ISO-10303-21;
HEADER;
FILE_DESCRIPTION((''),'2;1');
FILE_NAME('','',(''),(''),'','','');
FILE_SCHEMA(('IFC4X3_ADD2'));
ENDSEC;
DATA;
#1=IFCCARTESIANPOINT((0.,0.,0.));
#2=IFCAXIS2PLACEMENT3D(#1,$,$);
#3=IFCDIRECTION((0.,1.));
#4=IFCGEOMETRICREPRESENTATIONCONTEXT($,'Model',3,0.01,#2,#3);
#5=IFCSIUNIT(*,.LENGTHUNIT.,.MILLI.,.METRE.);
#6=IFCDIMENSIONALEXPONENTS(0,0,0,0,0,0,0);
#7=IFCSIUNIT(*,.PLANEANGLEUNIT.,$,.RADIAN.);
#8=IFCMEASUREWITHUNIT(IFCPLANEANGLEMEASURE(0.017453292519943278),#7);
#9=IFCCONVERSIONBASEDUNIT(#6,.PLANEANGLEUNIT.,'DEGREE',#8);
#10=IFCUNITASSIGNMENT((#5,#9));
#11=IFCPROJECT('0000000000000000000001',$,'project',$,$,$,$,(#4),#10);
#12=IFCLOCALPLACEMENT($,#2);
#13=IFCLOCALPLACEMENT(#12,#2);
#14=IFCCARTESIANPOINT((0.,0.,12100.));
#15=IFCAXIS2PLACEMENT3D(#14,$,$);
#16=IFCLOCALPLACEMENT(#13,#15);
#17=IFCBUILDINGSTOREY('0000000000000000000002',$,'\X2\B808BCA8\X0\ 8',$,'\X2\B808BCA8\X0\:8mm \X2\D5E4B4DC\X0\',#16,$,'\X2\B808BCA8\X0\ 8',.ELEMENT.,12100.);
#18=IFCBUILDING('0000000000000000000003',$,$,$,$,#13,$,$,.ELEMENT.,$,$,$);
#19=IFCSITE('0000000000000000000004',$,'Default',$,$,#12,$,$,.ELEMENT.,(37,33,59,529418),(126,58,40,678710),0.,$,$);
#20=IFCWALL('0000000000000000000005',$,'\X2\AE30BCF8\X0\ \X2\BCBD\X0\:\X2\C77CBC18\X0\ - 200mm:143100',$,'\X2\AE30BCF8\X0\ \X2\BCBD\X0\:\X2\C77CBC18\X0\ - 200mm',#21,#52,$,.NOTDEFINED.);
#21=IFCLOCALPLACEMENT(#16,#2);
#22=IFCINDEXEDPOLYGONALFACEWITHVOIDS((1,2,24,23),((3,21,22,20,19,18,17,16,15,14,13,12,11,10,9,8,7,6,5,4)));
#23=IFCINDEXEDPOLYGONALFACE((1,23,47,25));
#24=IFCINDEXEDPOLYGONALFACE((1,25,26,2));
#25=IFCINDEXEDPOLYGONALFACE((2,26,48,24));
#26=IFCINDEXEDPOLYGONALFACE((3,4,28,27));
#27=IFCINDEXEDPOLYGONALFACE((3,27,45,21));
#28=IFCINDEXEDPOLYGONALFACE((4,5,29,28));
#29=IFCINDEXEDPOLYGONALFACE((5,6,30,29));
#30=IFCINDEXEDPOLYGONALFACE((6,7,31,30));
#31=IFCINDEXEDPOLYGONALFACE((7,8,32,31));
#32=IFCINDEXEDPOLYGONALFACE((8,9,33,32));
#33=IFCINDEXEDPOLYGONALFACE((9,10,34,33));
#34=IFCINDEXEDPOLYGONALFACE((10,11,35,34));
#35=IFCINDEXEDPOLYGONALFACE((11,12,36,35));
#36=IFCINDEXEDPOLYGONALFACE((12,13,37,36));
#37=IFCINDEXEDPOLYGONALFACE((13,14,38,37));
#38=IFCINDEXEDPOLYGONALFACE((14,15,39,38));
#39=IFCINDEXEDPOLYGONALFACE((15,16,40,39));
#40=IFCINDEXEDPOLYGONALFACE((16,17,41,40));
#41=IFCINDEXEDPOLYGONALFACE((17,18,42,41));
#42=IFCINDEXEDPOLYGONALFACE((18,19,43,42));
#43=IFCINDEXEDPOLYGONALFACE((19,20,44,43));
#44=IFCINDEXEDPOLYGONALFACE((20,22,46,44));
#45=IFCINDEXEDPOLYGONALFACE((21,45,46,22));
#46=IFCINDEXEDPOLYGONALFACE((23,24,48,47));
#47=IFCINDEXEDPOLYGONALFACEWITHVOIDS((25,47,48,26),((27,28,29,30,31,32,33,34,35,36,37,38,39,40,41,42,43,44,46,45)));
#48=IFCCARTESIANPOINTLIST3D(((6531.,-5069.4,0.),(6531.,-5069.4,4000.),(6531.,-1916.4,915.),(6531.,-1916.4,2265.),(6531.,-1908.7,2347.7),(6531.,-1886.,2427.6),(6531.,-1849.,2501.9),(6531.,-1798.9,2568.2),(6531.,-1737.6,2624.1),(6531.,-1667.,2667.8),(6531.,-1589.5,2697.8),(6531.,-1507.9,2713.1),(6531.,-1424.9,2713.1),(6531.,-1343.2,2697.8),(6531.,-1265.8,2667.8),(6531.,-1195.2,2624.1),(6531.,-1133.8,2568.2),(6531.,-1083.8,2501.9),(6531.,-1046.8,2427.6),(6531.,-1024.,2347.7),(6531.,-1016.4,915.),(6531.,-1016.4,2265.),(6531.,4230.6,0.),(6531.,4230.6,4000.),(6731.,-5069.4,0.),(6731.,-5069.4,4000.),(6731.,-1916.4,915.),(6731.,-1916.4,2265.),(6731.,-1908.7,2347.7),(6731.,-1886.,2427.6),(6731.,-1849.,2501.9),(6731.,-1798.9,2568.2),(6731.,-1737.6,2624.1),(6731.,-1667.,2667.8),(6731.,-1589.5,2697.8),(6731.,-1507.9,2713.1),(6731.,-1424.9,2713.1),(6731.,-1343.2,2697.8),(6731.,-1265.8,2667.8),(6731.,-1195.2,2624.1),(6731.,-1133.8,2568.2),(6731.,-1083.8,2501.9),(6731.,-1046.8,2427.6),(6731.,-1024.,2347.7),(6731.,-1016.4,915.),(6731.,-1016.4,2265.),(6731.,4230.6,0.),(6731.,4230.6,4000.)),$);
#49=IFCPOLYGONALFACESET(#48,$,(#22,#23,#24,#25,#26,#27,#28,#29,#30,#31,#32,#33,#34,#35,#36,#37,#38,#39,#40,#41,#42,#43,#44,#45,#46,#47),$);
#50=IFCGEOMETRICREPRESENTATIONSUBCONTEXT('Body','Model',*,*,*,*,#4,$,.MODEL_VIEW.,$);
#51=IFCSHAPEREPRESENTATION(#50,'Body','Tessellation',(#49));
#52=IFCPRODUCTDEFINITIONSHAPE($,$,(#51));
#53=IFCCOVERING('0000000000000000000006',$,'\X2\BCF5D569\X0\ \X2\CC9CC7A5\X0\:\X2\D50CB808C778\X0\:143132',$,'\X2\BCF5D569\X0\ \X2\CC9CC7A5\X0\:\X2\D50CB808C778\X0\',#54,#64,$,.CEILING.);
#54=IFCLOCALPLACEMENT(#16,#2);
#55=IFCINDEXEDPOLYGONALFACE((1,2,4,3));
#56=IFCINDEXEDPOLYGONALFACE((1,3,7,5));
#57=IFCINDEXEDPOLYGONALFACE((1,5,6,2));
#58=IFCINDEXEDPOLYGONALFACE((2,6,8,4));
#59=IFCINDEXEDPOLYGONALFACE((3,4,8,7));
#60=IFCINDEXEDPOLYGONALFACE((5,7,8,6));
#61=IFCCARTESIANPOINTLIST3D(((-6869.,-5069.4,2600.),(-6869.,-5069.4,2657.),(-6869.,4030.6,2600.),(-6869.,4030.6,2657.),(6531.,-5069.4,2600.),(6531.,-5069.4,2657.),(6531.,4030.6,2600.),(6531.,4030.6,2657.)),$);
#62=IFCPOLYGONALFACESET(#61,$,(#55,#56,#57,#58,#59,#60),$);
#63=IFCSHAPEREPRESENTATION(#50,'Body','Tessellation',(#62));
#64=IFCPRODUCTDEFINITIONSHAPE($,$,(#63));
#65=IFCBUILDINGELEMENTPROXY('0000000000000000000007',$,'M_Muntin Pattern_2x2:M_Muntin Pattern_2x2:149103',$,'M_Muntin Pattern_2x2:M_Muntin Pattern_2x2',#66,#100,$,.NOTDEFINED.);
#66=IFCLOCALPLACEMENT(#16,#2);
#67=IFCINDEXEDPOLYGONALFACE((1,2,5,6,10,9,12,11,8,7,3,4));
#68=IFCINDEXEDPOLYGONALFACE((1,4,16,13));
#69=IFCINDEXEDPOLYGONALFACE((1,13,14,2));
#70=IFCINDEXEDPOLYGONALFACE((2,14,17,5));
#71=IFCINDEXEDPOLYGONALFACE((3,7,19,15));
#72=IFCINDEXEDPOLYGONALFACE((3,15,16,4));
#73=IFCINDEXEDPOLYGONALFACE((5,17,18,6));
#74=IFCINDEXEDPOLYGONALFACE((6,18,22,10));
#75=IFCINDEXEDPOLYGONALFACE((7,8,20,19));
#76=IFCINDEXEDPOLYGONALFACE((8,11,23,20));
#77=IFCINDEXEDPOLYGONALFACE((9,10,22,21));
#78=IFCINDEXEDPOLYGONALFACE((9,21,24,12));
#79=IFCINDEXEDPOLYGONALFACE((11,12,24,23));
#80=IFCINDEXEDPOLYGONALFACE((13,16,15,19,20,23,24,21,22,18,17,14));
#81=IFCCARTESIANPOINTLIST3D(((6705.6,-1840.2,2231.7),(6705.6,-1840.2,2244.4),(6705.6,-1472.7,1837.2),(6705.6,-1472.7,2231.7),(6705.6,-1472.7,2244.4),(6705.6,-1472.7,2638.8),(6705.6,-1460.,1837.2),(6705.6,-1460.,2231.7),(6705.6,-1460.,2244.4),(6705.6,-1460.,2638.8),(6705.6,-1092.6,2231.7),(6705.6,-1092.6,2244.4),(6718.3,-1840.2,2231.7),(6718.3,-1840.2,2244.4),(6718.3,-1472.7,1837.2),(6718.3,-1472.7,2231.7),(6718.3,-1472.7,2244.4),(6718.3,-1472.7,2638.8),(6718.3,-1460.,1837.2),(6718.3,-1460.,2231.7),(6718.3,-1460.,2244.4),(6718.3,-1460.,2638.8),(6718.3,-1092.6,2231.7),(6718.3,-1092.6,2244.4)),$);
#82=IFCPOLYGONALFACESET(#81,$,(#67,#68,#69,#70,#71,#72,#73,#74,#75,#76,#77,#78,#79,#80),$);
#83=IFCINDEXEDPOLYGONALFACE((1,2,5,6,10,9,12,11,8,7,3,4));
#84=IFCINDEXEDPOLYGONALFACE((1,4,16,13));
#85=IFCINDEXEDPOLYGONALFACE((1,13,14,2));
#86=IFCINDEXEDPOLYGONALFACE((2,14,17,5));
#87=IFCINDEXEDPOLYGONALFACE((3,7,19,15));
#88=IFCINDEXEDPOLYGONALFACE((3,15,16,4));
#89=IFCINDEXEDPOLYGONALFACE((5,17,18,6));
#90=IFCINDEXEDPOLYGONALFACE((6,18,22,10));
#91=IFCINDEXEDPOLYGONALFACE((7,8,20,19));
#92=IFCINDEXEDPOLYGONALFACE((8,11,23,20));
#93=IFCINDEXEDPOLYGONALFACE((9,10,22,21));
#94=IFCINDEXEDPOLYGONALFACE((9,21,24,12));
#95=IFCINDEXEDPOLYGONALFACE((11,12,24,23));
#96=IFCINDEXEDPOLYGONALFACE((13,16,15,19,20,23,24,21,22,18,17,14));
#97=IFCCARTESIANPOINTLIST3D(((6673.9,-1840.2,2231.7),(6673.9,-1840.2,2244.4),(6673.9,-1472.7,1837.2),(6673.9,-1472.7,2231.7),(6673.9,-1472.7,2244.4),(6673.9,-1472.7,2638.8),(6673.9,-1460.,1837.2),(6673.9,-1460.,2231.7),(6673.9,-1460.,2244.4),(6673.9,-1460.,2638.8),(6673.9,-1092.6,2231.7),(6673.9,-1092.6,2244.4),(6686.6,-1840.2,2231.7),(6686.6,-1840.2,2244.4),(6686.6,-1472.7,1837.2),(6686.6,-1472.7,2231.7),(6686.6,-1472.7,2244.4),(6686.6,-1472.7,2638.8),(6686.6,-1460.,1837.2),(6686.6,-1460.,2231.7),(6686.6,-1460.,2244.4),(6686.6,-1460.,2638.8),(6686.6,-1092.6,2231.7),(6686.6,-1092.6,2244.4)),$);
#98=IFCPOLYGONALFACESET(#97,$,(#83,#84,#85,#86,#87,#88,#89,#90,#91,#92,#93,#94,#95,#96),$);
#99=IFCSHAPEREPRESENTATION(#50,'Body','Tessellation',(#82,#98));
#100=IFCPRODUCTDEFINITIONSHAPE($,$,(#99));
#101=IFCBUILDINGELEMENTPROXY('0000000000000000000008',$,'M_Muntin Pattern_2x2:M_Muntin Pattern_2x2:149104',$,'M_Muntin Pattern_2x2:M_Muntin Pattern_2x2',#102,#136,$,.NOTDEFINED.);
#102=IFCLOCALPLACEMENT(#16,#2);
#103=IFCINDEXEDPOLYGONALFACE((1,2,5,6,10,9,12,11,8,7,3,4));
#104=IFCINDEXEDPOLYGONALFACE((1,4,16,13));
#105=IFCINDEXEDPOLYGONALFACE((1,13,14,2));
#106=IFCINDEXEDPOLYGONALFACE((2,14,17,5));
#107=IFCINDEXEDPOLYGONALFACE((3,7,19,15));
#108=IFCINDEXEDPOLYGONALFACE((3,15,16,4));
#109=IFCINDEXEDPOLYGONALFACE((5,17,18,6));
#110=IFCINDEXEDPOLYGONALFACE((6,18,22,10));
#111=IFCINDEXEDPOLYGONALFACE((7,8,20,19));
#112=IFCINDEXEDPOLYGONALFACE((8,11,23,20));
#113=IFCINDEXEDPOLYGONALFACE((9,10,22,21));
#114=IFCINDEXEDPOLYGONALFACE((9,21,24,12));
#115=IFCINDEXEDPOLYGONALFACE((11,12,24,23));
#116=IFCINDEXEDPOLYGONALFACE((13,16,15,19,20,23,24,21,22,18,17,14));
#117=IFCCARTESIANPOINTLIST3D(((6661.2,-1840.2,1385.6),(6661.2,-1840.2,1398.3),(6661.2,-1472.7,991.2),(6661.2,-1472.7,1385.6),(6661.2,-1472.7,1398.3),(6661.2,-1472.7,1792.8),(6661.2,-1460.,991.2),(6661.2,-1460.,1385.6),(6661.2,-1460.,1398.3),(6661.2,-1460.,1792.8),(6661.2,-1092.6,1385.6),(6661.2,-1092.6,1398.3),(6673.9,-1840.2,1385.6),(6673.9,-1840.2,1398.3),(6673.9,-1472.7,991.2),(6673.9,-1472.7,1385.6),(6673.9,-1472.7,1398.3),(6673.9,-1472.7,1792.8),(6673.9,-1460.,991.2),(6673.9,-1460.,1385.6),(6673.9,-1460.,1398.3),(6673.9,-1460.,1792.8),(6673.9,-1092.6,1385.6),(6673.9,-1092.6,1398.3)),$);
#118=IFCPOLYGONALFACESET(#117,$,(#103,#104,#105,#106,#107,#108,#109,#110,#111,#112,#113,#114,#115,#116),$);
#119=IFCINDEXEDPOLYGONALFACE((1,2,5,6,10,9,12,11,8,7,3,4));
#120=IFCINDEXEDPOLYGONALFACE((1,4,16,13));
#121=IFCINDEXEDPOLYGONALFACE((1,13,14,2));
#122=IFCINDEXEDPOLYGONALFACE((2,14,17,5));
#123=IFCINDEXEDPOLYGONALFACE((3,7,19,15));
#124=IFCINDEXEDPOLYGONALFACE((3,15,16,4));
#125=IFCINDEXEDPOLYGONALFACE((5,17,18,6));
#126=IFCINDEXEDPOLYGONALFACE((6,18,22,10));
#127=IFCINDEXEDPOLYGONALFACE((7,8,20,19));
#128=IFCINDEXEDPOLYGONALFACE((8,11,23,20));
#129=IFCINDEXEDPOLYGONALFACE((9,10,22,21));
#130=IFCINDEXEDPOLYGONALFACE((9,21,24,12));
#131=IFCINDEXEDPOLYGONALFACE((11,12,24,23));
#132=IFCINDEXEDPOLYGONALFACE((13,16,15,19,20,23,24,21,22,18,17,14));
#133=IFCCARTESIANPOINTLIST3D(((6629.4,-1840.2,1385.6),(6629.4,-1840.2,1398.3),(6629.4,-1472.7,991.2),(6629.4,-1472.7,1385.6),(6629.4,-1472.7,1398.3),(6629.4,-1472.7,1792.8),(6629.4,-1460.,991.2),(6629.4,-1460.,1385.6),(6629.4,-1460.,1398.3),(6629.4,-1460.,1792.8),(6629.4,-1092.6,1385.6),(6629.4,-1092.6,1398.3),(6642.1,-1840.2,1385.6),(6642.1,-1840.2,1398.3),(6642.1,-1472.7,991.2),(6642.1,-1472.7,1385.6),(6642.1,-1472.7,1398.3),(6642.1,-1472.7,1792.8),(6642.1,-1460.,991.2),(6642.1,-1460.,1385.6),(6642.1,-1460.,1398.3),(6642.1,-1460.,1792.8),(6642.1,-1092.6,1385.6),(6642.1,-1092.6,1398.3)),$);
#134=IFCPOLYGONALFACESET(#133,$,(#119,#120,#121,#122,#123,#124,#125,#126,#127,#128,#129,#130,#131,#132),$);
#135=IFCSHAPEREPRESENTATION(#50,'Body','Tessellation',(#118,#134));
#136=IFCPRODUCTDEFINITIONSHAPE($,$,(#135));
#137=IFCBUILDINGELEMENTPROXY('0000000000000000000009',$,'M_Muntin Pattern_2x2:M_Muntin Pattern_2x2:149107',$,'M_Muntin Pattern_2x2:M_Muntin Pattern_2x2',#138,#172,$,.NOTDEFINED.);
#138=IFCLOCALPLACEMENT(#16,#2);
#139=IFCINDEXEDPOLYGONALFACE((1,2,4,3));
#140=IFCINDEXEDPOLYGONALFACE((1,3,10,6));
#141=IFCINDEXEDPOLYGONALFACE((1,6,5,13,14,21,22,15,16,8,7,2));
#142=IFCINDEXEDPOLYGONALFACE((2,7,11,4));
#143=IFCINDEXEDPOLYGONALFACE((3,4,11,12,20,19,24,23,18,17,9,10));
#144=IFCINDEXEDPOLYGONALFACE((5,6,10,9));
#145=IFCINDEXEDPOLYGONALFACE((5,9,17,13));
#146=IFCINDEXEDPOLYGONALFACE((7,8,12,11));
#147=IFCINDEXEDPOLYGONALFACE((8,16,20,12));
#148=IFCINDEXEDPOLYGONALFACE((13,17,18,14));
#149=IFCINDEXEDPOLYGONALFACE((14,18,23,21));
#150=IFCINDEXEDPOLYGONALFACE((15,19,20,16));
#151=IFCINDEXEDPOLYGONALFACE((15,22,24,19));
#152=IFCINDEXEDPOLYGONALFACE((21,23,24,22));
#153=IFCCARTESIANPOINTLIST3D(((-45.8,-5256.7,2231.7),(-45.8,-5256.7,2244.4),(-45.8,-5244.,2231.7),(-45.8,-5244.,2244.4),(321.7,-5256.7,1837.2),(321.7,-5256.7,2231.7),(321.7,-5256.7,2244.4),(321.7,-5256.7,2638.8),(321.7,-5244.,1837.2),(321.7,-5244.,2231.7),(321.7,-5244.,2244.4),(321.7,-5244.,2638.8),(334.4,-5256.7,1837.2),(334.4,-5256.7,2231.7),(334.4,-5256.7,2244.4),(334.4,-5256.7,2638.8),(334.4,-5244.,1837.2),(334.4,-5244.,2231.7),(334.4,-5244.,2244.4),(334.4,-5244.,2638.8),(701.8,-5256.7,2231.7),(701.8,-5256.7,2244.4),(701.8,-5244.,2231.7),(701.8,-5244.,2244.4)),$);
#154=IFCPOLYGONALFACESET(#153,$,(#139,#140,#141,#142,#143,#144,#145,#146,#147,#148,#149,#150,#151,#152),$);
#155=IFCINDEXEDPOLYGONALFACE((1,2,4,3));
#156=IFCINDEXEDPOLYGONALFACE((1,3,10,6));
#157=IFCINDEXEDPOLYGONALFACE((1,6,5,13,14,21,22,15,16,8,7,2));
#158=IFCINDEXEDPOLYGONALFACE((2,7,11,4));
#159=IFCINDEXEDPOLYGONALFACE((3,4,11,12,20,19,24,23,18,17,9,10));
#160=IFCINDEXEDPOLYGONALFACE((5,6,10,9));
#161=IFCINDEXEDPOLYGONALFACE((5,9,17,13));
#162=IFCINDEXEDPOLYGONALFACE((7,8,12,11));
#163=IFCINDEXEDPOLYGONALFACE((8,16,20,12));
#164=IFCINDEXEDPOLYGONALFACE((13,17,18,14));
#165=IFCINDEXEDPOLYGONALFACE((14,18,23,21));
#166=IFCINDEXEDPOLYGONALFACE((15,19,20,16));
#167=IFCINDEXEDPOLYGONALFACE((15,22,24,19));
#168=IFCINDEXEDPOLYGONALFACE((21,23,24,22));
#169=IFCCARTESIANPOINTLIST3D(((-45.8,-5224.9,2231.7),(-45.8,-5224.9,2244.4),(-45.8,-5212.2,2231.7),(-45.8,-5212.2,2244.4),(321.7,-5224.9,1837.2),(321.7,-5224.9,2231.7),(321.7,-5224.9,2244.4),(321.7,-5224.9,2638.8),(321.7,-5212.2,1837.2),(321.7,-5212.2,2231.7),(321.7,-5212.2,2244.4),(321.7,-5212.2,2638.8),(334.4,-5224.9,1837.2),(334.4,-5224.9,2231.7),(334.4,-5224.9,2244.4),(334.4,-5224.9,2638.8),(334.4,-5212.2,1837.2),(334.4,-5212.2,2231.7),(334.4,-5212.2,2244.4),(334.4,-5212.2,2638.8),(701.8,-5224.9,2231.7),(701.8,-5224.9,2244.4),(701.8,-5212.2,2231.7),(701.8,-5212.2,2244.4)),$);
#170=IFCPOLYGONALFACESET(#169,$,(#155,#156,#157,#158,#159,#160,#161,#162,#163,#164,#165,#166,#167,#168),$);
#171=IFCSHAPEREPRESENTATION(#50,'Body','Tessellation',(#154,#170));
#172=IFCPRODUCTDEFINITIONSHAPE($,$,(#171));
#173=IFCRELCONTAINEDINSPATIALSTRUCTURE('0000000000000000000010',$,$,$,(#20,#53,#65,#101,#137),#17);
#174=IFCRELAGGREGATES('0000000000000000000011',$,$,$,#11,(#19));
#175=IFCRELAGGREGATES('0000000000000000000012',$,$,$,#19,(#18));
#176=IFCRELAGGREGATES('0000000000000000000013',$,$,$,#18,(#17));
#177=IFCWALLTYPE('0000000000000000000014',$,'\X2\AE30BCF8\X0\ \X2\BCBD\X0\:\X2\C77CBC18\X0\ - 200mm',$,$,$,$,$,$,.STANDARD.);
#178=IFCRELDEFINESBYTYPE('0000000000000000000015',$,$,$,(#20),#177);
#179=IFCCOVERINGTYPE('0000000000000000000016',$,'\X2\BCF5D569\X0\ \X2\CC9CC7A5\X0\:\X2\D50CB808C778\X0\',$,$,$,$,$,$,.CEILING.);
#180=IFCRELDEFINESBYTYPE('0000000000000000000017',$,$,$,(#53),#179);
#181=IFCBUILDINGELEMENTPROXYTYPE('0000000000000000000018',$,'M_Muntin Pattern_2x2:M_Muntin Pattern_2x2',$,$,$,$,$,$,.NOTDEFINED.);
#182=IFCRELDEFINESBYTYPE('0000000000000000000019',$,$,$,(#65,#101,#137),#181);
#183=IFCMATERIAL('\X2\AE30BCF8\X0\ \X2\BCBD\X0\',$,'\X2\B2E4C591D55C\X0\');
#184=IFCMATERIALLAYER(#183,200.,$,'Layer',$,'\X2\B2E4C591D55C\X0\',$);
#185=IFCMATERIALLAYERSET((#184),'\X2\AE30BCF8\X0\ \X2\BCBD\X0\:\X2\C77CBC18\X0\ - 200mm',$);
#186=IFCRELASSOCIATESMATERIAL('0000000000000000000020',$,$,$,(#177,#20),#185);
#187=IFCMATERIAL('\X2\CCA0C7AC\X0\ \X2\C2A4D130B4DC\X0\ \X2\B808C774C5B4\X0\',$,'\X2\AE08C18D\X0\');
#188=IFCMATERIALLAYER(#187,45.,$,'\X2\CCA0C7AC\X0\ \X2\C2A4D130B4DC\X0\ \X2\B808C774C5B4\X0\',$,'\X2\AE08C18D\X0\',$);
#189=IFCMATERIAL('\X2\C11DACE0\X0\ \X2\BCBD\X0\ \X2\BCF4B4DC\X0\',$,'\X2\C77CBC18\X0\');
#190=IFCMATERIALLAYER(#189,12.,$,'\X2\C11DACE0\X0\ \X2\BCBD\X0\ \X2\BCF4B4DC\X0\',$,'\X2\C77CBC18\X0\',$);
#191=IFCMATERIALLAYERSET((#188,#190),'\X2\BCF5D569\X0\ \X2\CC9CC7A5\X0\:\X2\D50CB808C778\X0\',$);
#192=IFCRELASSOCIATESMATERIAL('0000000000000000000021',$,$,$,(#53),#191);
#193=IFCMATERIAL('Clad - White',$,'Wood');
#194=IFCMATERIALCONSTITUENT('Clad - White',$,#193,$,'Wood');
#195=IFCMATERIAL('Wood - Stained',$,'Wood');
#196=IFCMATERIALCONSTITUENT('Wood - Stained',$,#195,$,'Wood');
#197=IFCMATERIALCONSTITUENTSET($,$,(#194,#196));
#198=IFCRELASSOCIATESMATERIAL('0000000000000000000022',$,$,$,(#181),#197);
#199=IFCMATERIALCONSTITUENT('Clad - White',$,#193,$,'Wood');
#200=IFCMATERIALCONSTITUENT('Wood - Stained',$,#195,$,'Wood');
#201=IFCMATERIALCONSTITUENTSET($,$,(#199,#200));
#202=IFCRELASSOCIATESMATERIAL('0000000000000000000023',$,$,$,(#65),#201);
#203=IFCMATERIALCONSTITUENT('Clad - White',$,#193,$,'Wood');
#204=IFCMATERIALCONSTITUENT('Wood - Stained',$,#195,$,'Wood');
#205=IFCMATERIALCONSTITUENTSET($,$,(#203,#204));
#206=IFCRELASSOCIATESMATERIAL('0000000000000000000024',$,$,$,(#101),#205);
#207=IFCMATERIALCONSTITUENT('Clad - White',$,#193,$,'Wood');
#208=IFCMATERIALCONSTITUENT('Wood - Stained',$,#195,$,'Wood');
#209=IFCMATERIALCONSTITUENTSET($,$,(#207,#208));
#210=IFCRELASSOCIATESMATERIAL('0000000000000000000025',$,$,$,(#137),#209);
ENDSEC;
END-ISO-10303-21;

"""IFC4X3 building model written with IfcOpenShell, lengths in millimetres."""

from ifc_helpers import new_model, entity, si_unit, converted_unit, direction, frame, frame_2d, origin, origin_2d_with_axis, place, context, subcontext, project, spatial, polyline, circle_curve, parameter, trimmed, segment, composite_curve, rectangle, outline, extrude, source, transform, mapped, material, layer, layer_set, layer_usage, constituent, constituent_set, type_object, type_shapes, element, save


model = new_model("IFC4X3")

# Units and contexts
model_context = context("Model", 3, precision=0.01, world=origin(), true_north=direction((0.0, 1.0)))
body_context = subcontext(model_context, "Body", "Model", "MODEL_VIEW")
ifc_project = project(units=[si_unit("LENGTHUNIT", "METRE", prefix="MILLI"), converted_unit("PLANEANGLEUNIT", "DEGREE", entity("IfcPlaneAngleMeasure", 0.017453292519943278), si_unit("PLANEANGLEUNIT", "RADIAN"), dimensions=[0, 0, 0, 0, 0, 0, 0])], contexts=[model_context])

# Site, building, storey
site_placement = place(None, origin())
site = spatial("IfcSite", under=ifc_project, at=site_placement, Name="Default", CompositionType="ELEMENT", RefLatitude=(37, 33, 59, 529418), RefLongitude=(126, 58, 40, 678710), RefElevation=0.0)
building_placement = place(site_placement, origin())
building = spatial("IfcBuilding", under=site, at=building_placement, CompositionType="ELEMENT")
storey_placement = place(building_placement, frame((0.0, 0.0, 12100.0)))
storey = spatial("IfcBuildingStorey", under=building, at=storey_placement, Name="레벨 8", ObjectType="레벨:8mm 헤드", LongName="레벨 8", CompositionType="ELEMENT", Elevation=12100.0)

# Shared definitions
ifc_material_1 = material(Name="기본 벽", Category="다양한")
ifc_layer_1 = layer(ifc_material_1, 200.0, Name="Layer", Category="다양한")
ifc_layer_set_1 = layer_set([ifc_layer_1], Name="기본 벽:일반 - 200mm")
wall_type = type_object("IfcWallType", Name="기본 벽:일반 - 200mm", PredefinedType="STANDARD", material=ifc_layer_set_1)

# Wall, opening
wall_1_placement = place(storey_placement, frame((6631.0, 4230.6, 0.0), z_axis=(0.0, 0.0, 1.0), x_axis=(0.0, -1.0, 0.0)))
wall_1 = element("IfcWall", 1, at=wall_1_placement, inside=storey, type_object=wall_type, material=ifc_layer_set_1, Name="기본 벽:일반 - 200mm:143100", ObjectType="기본 벽:일반 - 200mm", PredefinedType="NOTDEFINED", context=body_context, shape_type="SweptSolid", body=[
    extrude(rectangle(XDim=9300.0, YDim=200.0, at=frame_2d((4650.0, 0.0), x_axis=(-1.0, 0.0))), origin(), (0.0, 0.0, 1.0), 4000.0),
])
opening_1_placement = place(wall_1_placement, frame((5247.0, -100.0, 915.0)))
element("IfcOpeningElement", 2, at=opening_1_placement, cuts=wall_1, PredefinedType="OPENING", context=body_context, shape_type="SweptSolid", body=[
    extrude(outline(composite_curve([segment(polyline([(1350.0, 900.0), (0.0, 900.0)]), True, "CONTINUOUS"), segment(polyline([(0.0, 900.0), (0.0, 0.0)]), True, "CONTINUOUS"), segment(polyline([(0.0, 0.0), (1350.0, 0.0)]), True, "CONTINUOUS"), segment(trimmed(circle_curve(frame_2d((1350.0, 450.0), x_axis=(0.0, 1.0)), 450.0), [parameter(180.0)], [parameter(0.0)], True, "PARAMETER"), True, "CONTINUOUS")], self_intersect=False)), frame((0.0, 0.0, 0.0), z_axis=(0.0, 1.0, 0.0), x_axis=(0.0, 0.0, 1.0)), (0.0, 0.0, 1.0), 200.0),
])

# Covering
ifc_material_2 = material(Name="철재 스터드 레이어", Category="금속")
ifc_layer_2 = layer(ifc_material_2, 45.0, Name="철재 스터드 레이어", Category="금속")
ifc_material_3 = material(Name="석고 벽 보드", Category="일반")
ifc_layer_3 = layer(ifc_material_3, 12.0, Name="석고 벽 보드", Category="일반")
ifc_layer_set_2 = layer_set([ifc_layer_2, ifc_layer_3], Name="복합 천장:플레인")
ifc_layer_usage_1 = layer_usage(ifc_layer_set_2, "AXIS3", "NEGATIVE", 0.0)
covering_type = type_object("IfcCoveringType", Name="복합 천장:플레인", PredefinedType="CEILING")
covering_placement = place(storey_placement, frame((-6869.0, -5069.4, 2600.0)))
element("IfcCovering", 3, at=covering_placement, inside=storey, type_object=covering_type, material=ifc_layer_usage_1, Name="복합 천장:플레인:143132", ObjectType="복합 천장:플레인", PredefinedType="CEILING", context=body_context, shape_type="SweptSolid", body=[
    extrude(rectangle(XDim=9100.0, YDim=13400.0, at=origin_2d_with_axis()), frame((6700.0, 4550.0, 0.0), z_axis=(0.0, 0.0, 1.0), x_axis=(0.0, -1.0, 0.0)), (0.0, 0.0, 1.0), 57.0),
])

# Building element proxies
ifc_material_4 = material(Name="Clad - White", Category="Wood")
ifc_constituent_1 = constituent(ifc_material_4, Name="Clad - White", Category="Wood")
ifc_material_5 = material(Name="Wood - Stained", Category="Wood")
ifc_constituent_2 = constituent(ifc_material_5, Name="Wood - Stained", Category="Wood")
ifc_constituent_set_1 = constituent_set(constituents=[ifc_constituent_1, ifc_constituent_2])
ifc_constituent_3 = constituent(ifc_material_4, Name="Clad - White", Category="Wood")
ifc_constituent_4 = constituent(ifc_material_5, Name="Wood - Stained", Category="Wood")
ifc_constituent_set_2 = constituent_set(constituents=[ifc_constituent_3, ifc_constituent_4])
building_element_proxy_type_1 = type_object("IfcBuildingElementProxyType", Name="M_Muntin Pattern_2x2:M_Muntin Pattern_2x2", PredefinedType="NOTDEFINED", material=ifc_constituent_set_2)
shared_shape_1 = source(origin(), body_context, "Body", "SweptSolid", [
    extrude(outline(polyline([(6.4, -6.4), (400.8, -6.4), (400.8, 6.3), (6.4, 6.3), (6.4, 373.8), (-6.3, 373.8), (-6.3, 6.3), (-400.8, 6.3), (-400.8, -6.4), (-6.3, -6.4), (-6.3, -373.8), (6.4, -373.8), (6.4, -6.4)])), frame((0.0, 9.5, 400.8), z_axis=(0.0, 1.0, 0.0), x_axis=(0.0, 0.0, 1.0)), (0.0, 0.0, 1.0), 12.7),
    extrude(outline(polyline([(6.4, -6.4), (400.8, -6.4), (400.8, 6.3), (6.4, 6.3), (6.4, 373.8), (-6.3, 373.8), (-6.3, 6.3), (-400.8, 6.3), (-400.8, -6.4), (-6.3, -6.4), (-6.3, -373.8), (6.4, -373.8), (6.4, -6.4)])), frame((0.0, -22.2, 400.8), z_axis=(0.0, 1.0, 0.0), x_axis=(0.0, 0.0, 1.0)), (0.0, 0.0, 1.0), 12.7),
])
type_shapes(building_element_proxy_type_1, [shared_shape_1])
proxy_1_placement = place(storey_placement, frame((6696.1, -1466.4, 1837.2), z_axis=(0.0, 0.0, 1.0), x_axis=(0.0, -1.0, 0.0)))
element("IfcBuildingElementProxy", 4, at=proxy_1_placement, inside=storey, type_object=building_element_proxy_type_1, material=ifc_constituent_set_1, Name="M_Muntin Pattern_2x2:M_Muntin Pattern_2x2:149103", ObjectType="M_Muntin Pattern_2x2:M_Muntin Pattern_2x2", PredefinedType="NOTDEFINED", context=body_context, shape_type="MappedRepresentation", body=[
    mapped(shared_shape_1, transform((0.0, 0.0, 0.0), scale=1.0)),
])
ifc_constituent_5 = constituent(ifc_material_4, Name="Clad - White", Category="Wood")
ifc_constituent_6 = constituent(ifc_material_5, Name="Wood - Stained", Category="Wood")
ifc_constituent_set_3 = constituent_set(constituents=[ifc_constituent_5, ifc_constituent_6])
proxy_2_placement = place(storey_placement, frame((6651.7, -1466.4, 991.2), z_axis=(0.0, 0.0, 1.0), x_axis=(0.0, -1.0, 0.0)))
element("IfcBuildingElementProxy", 5, at=proxy_2_placement, inside=storey, type_object=building_element_proxy_type_1, material=ifc_constituent_set_3, Name="M_Muntin Pattern_2x2:M_Muntin Pattern_2x2:149104", ObjectType="M_Muntin Pattern_2x2:M_Muntin Pattern_2x2", PredefinedType="NOTDEFINED", context=body_context, shape_type="MappedRepresentation", body=[
    mapped(shared_shape_1, transform((0.0, 0.0, 0.0), scale=1.0)),
])
ifc_constituent_7 = constituent(ifc_material_4, Name="Clad - White", Category="Wood")
ifc_constituent_8 = constituent(ifc_material_5, Name="Wood - Stained", Category="Wood")
ifc_constituent_set_4 = constituent_set(constituents=[ifc_constituent_7, ifc_constituent_8])
proxy_3_placement = place(storey_placement, frame((328.0, -5234.4, 1837.2), z_axis=(0.0, 0.0, 1.0), x_axis=(-1.0, 0.0, 0.0)))
element("IfcBuildingElementProxy", 6, at=proxy_3_placement, inside=storey, type_object=building_element_proxy_type_1, material=ifc_constituent_set_4, Name="M_Muntin Pattern_2x2:M_Muntin Pattern_2x2:149107", ObjectType="M_Muntin Pattern_2x2:M_Muntin Pattern_2x2", PredefinedType="NOTDEFINED", context=body_context, shape_type="MappedRepresentation", body=[
    mapped(shared_shape_1, transform((0.0, 0.0, 0.0), scale=1.0)),
])

save(model, "model.ifc")
